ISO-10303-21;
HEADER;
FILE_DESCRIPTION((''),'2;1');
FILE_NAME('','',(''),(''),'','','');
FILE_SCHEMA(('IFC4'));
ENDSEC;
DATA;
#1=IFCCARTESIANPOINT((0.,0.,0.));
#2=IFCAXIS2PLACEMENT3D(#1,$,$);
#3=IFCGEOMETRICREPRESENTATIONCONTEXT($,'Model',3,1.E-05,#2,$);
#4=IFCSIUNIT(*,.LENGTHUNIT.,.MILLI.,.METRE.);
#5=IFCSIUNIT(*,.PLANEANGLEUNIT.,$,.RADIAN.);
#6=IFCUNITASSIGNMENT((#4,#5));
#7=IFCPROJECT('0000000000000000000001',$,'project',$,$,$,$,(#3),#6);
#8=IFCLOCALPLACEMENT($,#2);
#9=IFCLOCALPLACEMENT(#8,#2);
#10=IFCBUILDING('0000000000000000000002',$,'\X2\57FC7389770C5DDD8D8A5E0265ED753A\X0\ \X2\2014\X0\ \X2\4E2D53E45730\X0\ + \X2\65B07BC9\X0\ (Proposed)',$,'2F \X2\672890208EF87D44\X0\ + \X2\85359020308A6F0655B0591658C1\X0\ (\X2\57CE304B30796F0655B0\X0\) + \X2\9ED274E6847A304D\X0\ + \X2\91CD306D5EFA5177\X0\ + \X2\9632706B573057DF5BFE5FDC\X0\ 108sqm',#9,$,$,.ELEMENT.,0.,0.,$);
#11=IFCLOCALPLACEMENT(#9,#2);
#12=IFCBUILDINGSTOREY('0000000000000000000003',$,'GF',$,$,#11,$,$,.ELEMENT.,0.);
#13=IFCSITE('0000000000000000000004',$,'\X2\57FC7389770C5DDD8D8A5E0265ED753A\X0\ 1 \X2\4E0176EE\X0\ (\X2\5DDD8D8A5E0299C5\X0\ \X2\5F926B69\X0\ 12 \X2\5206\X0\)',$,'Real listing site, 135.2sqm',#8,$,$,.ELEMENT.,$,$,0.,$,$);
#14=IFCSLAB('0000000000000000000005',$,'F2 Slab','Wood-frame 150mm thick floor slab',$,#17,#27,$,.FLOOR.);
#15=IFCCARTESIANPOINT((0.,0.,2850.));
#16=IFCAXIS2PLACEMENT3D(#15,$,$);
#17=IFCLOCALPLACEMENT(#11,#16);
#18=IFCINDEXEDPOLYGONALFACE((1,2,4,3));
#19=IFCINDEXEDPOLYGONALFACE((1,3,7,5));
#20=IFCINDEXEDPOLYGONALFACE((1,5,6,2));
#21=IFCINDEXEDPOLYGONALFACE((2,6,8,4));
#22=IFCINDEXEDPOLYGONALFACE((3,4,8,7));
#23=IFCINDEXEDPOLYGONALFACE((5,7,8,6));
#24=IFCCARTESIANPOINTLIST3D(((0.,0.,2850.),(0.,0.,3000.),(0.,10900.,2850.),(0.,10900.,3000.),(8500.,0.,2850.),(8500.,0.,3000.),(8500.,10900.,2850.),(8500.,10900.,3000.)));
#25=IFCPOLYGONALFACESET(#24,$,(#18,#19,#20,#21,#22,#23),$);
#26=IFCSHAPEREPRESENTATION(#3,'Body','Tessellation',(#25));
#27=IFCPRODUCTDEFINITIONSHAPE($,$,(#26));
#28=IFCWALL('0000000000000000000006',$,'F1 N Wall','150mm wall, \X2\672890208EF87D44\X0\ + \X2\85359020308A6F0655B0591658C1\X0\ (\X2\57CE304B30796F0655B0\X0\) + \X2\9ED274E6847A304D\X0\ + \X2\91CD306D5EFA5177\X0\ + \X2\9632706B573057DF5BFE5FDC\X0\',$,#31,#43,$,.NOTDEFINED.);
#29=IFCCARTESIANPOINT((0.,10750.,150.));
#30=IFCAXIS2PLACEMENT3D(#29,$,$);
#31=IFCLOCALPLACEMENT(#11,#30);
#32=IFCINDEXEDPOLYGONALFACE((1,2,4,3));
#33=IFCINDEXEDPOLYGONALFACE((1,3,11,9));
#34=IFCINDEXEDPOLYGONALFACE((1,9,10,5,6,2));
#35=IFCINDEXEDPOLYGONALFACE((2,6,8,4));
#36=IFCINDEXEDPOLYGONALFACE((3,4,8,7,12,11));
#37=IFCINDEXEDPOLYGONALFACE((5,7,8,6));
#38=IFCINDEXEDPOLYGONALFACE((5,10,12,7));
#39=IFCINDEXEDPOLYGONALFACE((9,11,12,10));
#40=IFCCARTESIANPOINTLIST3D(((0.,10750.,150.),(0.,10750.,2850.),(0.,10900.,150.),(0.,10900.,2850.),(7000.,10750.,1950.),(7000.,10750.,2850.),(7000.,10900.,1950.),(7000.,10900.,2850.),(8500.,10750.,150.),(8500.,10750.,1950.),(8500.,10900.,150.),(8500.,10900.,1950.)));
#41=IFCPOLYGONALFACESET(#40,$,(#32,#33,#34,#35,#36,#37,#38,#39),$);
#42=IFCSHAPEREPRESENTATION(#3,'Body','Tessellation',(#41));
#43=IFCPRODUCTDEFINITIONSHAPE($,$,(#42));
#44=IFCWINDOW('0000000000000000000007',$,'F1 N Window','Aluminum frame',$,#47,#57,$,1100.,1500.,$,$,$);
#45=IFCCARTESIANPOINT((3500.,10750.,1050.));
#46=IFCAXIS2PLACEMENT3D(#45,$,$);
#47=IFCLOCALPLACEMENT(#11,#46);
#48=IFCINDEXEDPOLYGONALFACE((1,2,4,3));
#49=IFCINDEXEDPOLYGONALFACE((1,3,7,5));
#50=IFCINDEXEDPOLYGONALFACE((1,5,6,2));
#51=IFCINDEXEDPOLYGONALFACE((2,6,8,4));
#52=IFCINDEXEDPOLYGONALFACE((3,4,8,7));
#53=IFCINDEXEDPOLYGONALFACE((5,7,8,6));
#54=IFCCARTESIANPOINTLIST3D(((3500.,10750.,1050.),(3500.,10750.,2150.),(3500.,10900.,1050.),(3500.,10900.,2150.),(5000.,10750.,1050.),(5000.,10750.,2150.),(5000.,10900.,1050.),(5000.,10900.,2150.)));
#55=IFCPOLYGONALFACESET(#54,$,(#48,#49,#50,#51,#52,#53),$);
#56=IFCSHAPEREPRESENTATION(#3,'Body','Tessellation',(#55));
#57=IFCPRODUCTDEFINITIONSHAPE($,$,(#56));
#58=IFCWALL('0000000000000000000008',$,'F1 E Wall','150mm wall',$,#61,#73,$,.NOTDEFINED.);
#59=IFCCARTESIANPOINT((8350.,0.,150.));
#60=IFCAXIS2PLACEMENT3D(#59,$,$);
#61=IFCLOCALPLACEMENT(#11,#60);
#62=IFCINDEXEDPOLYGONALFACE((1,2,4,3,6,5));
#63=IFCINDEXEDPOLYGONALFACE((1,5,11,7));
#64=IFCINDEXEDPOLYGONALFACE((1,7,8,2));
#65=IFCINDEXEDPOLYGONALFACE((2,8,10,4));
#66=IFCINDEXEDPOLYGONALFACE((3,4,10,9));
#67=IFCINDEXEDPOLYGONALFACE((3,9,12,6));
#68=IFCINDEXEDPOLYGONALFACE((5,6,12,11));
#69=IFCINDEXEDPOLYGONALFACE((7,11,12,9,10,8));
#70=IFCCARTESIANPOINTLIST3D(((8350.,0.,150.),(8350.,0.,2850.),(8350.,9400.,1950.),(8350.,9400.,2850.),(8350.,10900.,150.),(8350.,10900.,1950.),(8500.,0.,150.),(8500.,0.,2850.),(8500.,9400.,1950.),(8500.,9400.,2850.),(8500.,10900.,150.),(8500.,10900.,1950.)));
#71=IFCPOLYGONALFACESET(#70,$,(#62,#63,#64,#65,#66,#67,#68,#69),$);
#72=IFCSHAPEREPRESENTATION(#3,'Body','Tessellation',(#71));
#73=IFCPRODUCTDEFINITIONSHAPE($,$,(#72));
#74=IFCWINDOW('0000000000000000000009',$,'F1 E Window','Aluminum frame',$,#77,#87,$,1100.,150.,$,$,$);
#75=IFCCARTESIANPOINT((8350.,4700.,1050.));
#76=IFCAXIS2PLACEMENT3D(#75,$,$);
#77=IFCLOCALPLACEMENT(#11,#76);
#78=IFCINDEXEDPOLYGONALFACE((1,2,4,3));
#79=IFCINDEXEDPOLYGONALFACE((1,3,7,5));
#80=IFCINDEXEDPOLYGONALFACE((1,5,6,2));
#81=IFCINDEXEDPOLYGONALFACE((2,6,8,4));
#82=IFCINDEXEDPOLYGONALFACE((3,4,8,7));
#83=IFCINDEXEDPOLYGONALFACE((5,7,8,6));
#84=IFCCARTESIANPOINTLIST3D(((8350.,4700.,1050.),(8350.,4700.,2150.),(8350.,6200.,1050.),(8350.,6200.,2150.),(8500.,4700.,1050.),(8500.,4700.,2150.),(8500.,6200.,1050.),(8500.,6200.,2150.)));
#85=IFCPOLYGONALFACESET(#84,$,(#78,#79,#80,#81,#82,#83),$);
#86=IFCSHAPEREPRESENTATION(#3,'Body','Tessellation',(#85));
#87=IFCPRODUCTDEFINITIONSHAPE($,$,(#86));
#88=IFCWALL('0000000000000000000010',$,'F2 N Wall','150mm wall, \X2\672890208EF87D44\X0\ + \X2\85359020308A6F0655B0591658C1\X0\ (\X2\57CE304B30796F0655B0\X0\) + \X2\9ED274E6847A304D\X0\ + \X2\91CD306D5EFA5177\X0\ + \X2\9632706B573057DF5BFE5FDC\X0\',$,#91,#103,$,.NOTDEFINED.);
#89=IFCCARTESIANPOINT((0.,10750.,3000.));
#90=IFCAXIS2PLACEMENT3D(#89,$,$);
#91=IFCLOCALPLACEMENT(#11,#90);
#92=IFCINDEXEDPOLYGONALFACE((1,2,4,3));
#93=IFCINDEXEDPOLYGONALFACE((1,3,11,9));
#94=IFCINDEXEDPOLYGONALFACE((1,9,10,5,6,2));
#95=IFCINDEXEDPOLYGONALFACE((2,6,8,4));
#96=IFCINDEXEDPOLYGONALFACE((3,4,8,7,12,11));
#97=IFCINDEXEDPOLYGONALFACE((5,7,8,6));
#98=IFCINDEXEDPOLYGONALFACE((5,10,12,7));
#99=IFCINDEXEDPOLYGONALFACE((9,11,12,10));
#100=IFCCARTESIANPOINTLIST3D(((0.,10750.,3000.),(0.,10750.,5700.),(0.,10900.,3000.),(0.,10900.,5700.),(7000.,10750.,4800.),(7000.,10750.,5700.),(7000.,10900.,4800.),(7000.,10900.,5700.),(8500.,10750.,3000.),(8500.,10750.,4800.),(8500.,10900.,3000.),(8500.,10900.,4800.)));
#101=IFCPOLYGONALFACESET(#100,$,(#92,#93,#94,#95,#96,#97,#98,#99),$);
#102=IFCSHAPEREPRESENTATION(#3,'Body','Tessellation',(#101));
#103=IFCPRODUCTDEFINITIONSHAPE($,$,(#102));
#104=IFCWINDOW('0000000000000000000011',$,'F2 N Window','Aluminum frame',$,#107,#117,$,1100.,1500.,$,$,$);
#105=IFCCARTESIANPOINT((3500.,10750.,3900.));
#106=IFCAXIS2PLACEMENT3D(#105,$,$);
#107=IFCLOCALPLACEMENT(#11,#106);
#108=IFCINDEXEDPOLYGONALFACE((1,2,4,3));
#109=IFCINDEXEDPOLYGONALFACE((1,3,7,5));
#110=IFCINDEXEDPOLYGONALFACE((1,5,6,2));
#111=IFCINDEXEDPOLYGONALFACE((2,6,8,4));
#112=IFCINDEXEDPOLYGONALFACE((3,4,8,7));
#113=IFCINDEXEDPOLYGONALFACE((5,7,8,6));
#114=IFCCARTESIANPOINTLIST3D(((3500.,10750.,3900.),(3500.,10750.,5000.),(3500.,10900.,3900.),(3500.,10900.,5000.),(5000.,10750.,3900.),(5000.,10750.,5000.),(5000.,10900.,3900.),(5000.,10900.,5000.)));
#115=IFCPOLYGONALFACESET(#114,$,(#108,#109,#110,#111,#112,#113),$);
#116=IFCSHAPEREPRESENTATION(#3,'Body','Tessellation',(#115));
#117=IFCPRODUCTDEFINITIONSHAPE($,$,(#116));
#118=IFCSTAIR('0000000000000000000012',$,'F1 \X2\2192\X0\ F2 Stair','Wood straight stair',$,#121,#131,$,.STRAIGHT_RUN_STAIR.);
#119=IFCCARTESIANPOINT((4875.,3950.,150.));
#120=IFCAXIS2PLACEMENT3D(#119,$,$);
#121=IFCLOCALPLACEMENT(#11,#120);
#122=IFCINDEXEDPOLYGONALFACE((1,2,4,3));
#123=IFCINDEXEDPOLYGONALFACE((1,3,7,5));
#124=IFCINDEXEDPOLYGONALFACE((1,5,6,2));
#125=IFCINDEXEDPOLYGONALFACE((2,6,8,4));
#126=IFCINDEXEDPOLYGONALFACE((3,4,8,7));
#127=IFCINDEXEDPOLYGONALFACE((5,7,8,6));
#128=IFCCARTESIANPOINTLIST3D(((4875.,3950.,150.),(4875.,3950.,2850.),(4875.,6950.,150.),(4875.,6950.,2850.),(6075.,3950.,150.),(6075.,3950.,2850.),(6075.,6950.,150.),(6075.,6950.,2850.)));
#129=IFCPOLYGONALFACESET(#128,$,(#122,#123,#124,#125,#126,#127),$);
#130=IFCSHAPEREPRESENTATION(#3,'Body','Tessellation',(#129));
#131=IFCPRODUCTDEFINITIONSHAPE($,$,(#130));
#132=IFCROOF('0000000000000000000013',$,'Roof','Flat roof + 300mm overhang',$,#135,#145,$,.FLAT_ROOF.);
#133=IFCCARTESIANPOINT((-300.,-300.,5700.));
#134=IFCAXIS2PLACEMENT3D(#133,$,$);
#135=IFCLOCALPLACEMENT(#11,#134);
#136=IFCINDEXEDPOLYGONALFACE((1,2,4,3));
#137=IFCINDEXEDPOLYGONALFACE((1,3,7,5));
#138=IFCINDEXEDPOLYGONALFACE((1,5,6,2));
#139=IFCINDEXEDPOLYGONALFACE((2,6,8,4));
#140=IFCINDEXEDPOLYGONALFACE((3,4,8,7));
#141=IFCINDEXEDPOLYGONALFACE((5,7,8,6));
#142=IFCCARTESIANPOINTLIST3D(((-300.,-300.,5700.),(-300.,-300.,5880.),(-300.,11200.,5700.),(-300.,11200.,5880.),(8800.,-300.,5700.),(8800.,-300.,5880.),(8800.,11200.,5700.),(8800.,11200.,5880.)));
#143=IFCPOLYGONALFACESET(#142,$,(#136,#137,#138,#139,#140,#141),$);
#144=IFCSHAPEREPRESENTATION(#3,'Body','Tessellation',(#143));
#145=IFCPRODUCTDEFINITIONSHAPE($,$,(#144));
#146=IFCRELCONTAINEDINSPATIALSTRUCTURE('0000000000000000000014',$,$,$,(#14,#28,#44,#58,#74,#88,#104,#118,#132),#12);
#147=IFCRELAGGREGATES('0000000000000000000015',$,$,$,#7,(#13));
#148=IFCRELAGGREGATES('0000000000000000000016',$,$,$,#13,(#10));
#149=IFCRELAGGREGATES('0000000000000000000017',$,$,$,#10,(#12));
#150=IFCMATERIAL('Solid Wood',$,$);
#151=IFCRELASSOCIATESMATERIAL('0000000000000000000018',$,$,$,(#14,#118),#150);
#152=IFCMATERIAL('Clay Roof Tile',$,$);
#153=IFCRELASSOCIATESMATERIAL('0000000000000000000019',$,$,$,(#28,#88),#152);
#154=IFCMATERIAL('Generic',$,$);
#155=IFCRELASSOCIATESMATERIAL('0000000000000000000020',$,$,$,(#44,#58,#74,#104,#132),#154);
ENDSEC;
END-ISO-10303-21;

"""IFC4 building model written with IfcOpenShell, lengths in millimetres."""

from ifc_helpers import new_model, si_unit, frame, frame_2d, origin, place, context, project, spatial, rectangle, extrude, material, element, fill, save


model = new_model("IFC4")

# Units and contexts
model_context = context("Model", 3, precision=1e-05, world=origin())
ifc_project = project(units=[si_unit("LENGTHUNIT", "METRE", prefix="MILLI"), si_unit("PLANEANGLEUNIT", "RADIAN")], contexts=[model_context])

# Site, building, storey
site_placement = place(None, origin())
site = spatial("IfcSite", under=ifc_project, at=site_placement, Name="埼玉県川越市旭町 1 丁目 (川越市駅 徒歩 12 分)", ObjectType="Real listing site, 135.2sqm", CompositionType="ELEMENT", RefElevation=0.0)
building_placement = place(site_placement, origin())
building = spatial("IfcBuilding", under=site, at=building_placement, Name="埼玉県川越市旭町 — 中古地 + 新築 (Proposed)", ObjectType="2F 木造軸組 + 蔵造り漆喰外壁 (城かべ漆喰) + 黒瓦葺き + 重ね建具 + 防火地域対応 108sqm", CompositionType="ELEMENT", ElevationOfRefHeight=0.0, ElevationOfTerrain=0.0)
storey_placement = place(building_placement, origin())
storey = spatial("IfcBuildingStorey", under=building, at=storey_placement, Name="GF", CompositionType="ELEMENT", Elevation=0.0)

# Slab
ifc_material_1 = material(Name="Solid Wood")
slab_1_placement = place(storey_placement, frame((0.0, 0.0, 2850.0)))
element("IfcSlab", 1, at=slab_1_placement, inside=storey, material=ifc_material_1, Name="F2 Slab", Description="Wood-frame 150mm thick floor slab", PredefinedType="FLOOR", context=model_context, shape_type="SweptSolid", body=[
    extrude(rectangle(XDim=8500.0, YDim=10900.0, at=frame_2d((4250.0, 5450.0))), frame((0.0, 0.0, 2850.0)), (0.0, 0.0, 1.0), 150.0),
])

# Wall, opening, window
ifc_material_2 = material(Name="Clay Roof Tile")
wall_1_placement = place(storey_placement, frame((0.0, 10750.0, 150.0)))
wall_1 = element("IfcWall", 2, at=wall_1_placement, inside=storey, material=ifc_material_2, Name="F1 N Wall", Description="150mm wall, 木造軸組 + 蔵造り漆喰外壁 (城かべ漆喰) + 黒瓦葺き + 重ね建具 + 防火地域対応", PredefinedType="NOTDEFINED", context=model_context, shape_type="SweptSolid", body=[
    extrude(rectangle(XDim=8500.0, YDim=150.0, at=frame_2d((4250.0, 75.0))), frame((0.0, 10750.0, 150.0)), (0.0, 0.0, 1.0), 2700.0),
])
opening_1_placement = place(storey_placement, frame((3500.0, 10750.0, 1050.0)))
opening_1 = element("IfcOpeningElement", 3, at=opening_1_placement, cuts=wall_1, PredefinedType="NOTDEFINED", context=model_context, shape_type="SweptSolid", body=[
    extrude(rectangle(XDim=1500.0, YDim=150.0, at=frame_2d((750.0, 75.0))), frame((3500.0, 10750.0, 1050.0)), (0.0, 0.0, 1.0), 1100.0),
])
ifc_material_3 = material(Name="Generic")
window_1_placement = place(storey_placement, frame((3500.0, 10750.0, 1050.0)))
window_1 = element("IfcWindow", 4, at=window_1_placement, inside=storey, material=ifc_material_3, Name="F1 N Window", Description="Aluminum frame", OverallHeight=1100.0, OverallWidth=1500.0, context=model_context, shape_type="SweptSolid", body=[
    extrude(rectangle(XDim=1500.0, YDim=150.0, at=frame_2d((750.0, 75.0))), frame((3500.0, 10750.0, 1050.0)), (0.0, 0.0, 1.0), 1100.0),
])
fill(opening_1, window_1)

# Walls, openings, windows
wall_2_placement = place(storey_placement, frame((8350.0, 0.0, 150.0)))
wall_2 = element("IfcWall", 5, at=wall_2_placement, inside=storey, material=ifc_material_3, Name="F1 E Wall", Description="150mm wall", PredefinedType="NOTDEFINED", context=model_context, shape_type="SweptSolid", body=[
    extrude(rectangle(XDim=150.0, YDim=10900.0, at=frame_2d((75.0, 5450.0))), frame((8350.0, 0.0, 150.0)), (0.0, 0.0, 1.0), 2700.0),
])
opening_2_placement = place(storey_placement, frame((8350.0, 4700.0, 1050.0)))
opening_2 = element("IfcOpeningElement", 6, at=opening_2_placement, cuts=wall_2, PredefinedType="NOTDEFINED", context=model_context, shape_type="SweptSolid", body=[
    extrude(rectangle(XDim=150.0, YDim=1500.0, at=frame_2d((75.0, 750.0))), frame((8350.0, 4700.0, 1050.0)), (0.0, 0.0, 1.0), 1100.0),
])
window_2_placement = place(storey_placement, frame((8350.0, 4700.0, 1050.0)))
window_2 = element("IfcWindow", 7, at=window_2_placement, inside=storey, material=ifc_material_3, Name="F1 E Window", Description="Aluminum frame", OverallHeight=1100.0, OverallWidth=150.0, context=model_context, shape_type="SweptSolid", body=[
    extrude(rectangle(XDim=150.0, YDim=1500.0, at=frame_2d((75.0, 750.0))), frame((8350.0, 4700.0, 1050.0)), (0.0, 0.0, 1.0), 1100.0),
])
fill(opening_2, window_2)
wall_3_placement = place(storey_placement, frame((0.0, 10750.0, 3000.0)))
wall_3 = element("IfcWall", 8, at=wall_3_placement, inside=storey, material=ifc_material_2, Name="F2 N Wall", Description="150mm wall, 木造軸組 + 蔵造り漆喰外壁 (城かべ漆喰) + 黒瓦葺き + 重ね建具 + 防火地域対応", PredefinedType="NOTDEFINED", context=model_context, shape_type="SweptSolid", body=[
    extrude(rectangle(XDim=8500.0, YDim=150.0, at=frame_2d((4250.0, 75.0))), frame((0.0, 10750.0, 3000.0)), (0.0, 0.0, 1.0), 2700.0),
])
opening_3_placement = place(storey_placement, frame((3500.0, 10750.0, 3900.0)))
opening_3 = element("IfcOpeningElement", 9, at=opening_3_placement, cuts=wall_3, PredefinedType="NOTDEFINED", context=model_context, shape_type="SweptSolid", body=[
    extrude(rectangle(XDim=1500.0, YDim=150.0, at=frame_2d((750.0, 75.0))), frame((3500.0, 10750.0, 3900.0)), (0.0, 0.0, 1.0), 1100.0),
])
window_3_placement = place(storey_placement, frame((3500.0, 10750.0, 3900.0)))
window_3 = element("IfcWindow", 10, at=window_3_placement, inside=storey, material=ifc_material_3, Name="F2 N Window", Description="Aluminum frame", OverallHeight=1100.0, OverallWidth=1500.0, context=model_context, shape_type="SweptSolid", body=[
    extrude(rectangle(XDim=1500.0, YDim=150.0, at=frame_2d((750.0, 75.0))), frame((3500.0, 10750.0, 3900.0)), (0.0, 0.0, 1.0), 1100.0),
])
fill(opening_3, window_3)

# Stair
stair_placement = place(storey_placement, frame((4875.0, 3950.0, 150.0)))
element("IfcStair", 11, at=stair_placement, inside=storey, material=ifc_material_1, Name="F1 → F2 Stair", Description="Wood straight stair", PredefinedType="STRAIGHT_RUN_STAIR", context=model_context, shape_type="SweptSolid", body=[
    extrude(rectangle(XDim=1200.0, YDim=3000.0, at=frame_2d((600.0, 1500.0))), frame((4875.0, 3950.0, 150.0)), (0.0, 0.0, 1.0), 2700.0),
])

# Roof
roof_placement = place(storey_placement, frame((-300.0, -300.0, 5700.0)))
element("IfcRoof", 12, at=roof_placement, inside=storey, material=ifc_material_3, Name="Roof", Description="Flat roof + 300mm overhang", PredefinedType="FLAT_ROOF", context=model_context, shape_type="SweptSolid", body=[
    extrude(rectangle(XDim=9100.0, YDim=11500.0, at=frame_2d((4550.0, 5750.0))), frame((-300.0, -300.0, 5700.0)), (0.0, 0.0, 1.0), 180.0),
])

save(model, "model.ifc")
